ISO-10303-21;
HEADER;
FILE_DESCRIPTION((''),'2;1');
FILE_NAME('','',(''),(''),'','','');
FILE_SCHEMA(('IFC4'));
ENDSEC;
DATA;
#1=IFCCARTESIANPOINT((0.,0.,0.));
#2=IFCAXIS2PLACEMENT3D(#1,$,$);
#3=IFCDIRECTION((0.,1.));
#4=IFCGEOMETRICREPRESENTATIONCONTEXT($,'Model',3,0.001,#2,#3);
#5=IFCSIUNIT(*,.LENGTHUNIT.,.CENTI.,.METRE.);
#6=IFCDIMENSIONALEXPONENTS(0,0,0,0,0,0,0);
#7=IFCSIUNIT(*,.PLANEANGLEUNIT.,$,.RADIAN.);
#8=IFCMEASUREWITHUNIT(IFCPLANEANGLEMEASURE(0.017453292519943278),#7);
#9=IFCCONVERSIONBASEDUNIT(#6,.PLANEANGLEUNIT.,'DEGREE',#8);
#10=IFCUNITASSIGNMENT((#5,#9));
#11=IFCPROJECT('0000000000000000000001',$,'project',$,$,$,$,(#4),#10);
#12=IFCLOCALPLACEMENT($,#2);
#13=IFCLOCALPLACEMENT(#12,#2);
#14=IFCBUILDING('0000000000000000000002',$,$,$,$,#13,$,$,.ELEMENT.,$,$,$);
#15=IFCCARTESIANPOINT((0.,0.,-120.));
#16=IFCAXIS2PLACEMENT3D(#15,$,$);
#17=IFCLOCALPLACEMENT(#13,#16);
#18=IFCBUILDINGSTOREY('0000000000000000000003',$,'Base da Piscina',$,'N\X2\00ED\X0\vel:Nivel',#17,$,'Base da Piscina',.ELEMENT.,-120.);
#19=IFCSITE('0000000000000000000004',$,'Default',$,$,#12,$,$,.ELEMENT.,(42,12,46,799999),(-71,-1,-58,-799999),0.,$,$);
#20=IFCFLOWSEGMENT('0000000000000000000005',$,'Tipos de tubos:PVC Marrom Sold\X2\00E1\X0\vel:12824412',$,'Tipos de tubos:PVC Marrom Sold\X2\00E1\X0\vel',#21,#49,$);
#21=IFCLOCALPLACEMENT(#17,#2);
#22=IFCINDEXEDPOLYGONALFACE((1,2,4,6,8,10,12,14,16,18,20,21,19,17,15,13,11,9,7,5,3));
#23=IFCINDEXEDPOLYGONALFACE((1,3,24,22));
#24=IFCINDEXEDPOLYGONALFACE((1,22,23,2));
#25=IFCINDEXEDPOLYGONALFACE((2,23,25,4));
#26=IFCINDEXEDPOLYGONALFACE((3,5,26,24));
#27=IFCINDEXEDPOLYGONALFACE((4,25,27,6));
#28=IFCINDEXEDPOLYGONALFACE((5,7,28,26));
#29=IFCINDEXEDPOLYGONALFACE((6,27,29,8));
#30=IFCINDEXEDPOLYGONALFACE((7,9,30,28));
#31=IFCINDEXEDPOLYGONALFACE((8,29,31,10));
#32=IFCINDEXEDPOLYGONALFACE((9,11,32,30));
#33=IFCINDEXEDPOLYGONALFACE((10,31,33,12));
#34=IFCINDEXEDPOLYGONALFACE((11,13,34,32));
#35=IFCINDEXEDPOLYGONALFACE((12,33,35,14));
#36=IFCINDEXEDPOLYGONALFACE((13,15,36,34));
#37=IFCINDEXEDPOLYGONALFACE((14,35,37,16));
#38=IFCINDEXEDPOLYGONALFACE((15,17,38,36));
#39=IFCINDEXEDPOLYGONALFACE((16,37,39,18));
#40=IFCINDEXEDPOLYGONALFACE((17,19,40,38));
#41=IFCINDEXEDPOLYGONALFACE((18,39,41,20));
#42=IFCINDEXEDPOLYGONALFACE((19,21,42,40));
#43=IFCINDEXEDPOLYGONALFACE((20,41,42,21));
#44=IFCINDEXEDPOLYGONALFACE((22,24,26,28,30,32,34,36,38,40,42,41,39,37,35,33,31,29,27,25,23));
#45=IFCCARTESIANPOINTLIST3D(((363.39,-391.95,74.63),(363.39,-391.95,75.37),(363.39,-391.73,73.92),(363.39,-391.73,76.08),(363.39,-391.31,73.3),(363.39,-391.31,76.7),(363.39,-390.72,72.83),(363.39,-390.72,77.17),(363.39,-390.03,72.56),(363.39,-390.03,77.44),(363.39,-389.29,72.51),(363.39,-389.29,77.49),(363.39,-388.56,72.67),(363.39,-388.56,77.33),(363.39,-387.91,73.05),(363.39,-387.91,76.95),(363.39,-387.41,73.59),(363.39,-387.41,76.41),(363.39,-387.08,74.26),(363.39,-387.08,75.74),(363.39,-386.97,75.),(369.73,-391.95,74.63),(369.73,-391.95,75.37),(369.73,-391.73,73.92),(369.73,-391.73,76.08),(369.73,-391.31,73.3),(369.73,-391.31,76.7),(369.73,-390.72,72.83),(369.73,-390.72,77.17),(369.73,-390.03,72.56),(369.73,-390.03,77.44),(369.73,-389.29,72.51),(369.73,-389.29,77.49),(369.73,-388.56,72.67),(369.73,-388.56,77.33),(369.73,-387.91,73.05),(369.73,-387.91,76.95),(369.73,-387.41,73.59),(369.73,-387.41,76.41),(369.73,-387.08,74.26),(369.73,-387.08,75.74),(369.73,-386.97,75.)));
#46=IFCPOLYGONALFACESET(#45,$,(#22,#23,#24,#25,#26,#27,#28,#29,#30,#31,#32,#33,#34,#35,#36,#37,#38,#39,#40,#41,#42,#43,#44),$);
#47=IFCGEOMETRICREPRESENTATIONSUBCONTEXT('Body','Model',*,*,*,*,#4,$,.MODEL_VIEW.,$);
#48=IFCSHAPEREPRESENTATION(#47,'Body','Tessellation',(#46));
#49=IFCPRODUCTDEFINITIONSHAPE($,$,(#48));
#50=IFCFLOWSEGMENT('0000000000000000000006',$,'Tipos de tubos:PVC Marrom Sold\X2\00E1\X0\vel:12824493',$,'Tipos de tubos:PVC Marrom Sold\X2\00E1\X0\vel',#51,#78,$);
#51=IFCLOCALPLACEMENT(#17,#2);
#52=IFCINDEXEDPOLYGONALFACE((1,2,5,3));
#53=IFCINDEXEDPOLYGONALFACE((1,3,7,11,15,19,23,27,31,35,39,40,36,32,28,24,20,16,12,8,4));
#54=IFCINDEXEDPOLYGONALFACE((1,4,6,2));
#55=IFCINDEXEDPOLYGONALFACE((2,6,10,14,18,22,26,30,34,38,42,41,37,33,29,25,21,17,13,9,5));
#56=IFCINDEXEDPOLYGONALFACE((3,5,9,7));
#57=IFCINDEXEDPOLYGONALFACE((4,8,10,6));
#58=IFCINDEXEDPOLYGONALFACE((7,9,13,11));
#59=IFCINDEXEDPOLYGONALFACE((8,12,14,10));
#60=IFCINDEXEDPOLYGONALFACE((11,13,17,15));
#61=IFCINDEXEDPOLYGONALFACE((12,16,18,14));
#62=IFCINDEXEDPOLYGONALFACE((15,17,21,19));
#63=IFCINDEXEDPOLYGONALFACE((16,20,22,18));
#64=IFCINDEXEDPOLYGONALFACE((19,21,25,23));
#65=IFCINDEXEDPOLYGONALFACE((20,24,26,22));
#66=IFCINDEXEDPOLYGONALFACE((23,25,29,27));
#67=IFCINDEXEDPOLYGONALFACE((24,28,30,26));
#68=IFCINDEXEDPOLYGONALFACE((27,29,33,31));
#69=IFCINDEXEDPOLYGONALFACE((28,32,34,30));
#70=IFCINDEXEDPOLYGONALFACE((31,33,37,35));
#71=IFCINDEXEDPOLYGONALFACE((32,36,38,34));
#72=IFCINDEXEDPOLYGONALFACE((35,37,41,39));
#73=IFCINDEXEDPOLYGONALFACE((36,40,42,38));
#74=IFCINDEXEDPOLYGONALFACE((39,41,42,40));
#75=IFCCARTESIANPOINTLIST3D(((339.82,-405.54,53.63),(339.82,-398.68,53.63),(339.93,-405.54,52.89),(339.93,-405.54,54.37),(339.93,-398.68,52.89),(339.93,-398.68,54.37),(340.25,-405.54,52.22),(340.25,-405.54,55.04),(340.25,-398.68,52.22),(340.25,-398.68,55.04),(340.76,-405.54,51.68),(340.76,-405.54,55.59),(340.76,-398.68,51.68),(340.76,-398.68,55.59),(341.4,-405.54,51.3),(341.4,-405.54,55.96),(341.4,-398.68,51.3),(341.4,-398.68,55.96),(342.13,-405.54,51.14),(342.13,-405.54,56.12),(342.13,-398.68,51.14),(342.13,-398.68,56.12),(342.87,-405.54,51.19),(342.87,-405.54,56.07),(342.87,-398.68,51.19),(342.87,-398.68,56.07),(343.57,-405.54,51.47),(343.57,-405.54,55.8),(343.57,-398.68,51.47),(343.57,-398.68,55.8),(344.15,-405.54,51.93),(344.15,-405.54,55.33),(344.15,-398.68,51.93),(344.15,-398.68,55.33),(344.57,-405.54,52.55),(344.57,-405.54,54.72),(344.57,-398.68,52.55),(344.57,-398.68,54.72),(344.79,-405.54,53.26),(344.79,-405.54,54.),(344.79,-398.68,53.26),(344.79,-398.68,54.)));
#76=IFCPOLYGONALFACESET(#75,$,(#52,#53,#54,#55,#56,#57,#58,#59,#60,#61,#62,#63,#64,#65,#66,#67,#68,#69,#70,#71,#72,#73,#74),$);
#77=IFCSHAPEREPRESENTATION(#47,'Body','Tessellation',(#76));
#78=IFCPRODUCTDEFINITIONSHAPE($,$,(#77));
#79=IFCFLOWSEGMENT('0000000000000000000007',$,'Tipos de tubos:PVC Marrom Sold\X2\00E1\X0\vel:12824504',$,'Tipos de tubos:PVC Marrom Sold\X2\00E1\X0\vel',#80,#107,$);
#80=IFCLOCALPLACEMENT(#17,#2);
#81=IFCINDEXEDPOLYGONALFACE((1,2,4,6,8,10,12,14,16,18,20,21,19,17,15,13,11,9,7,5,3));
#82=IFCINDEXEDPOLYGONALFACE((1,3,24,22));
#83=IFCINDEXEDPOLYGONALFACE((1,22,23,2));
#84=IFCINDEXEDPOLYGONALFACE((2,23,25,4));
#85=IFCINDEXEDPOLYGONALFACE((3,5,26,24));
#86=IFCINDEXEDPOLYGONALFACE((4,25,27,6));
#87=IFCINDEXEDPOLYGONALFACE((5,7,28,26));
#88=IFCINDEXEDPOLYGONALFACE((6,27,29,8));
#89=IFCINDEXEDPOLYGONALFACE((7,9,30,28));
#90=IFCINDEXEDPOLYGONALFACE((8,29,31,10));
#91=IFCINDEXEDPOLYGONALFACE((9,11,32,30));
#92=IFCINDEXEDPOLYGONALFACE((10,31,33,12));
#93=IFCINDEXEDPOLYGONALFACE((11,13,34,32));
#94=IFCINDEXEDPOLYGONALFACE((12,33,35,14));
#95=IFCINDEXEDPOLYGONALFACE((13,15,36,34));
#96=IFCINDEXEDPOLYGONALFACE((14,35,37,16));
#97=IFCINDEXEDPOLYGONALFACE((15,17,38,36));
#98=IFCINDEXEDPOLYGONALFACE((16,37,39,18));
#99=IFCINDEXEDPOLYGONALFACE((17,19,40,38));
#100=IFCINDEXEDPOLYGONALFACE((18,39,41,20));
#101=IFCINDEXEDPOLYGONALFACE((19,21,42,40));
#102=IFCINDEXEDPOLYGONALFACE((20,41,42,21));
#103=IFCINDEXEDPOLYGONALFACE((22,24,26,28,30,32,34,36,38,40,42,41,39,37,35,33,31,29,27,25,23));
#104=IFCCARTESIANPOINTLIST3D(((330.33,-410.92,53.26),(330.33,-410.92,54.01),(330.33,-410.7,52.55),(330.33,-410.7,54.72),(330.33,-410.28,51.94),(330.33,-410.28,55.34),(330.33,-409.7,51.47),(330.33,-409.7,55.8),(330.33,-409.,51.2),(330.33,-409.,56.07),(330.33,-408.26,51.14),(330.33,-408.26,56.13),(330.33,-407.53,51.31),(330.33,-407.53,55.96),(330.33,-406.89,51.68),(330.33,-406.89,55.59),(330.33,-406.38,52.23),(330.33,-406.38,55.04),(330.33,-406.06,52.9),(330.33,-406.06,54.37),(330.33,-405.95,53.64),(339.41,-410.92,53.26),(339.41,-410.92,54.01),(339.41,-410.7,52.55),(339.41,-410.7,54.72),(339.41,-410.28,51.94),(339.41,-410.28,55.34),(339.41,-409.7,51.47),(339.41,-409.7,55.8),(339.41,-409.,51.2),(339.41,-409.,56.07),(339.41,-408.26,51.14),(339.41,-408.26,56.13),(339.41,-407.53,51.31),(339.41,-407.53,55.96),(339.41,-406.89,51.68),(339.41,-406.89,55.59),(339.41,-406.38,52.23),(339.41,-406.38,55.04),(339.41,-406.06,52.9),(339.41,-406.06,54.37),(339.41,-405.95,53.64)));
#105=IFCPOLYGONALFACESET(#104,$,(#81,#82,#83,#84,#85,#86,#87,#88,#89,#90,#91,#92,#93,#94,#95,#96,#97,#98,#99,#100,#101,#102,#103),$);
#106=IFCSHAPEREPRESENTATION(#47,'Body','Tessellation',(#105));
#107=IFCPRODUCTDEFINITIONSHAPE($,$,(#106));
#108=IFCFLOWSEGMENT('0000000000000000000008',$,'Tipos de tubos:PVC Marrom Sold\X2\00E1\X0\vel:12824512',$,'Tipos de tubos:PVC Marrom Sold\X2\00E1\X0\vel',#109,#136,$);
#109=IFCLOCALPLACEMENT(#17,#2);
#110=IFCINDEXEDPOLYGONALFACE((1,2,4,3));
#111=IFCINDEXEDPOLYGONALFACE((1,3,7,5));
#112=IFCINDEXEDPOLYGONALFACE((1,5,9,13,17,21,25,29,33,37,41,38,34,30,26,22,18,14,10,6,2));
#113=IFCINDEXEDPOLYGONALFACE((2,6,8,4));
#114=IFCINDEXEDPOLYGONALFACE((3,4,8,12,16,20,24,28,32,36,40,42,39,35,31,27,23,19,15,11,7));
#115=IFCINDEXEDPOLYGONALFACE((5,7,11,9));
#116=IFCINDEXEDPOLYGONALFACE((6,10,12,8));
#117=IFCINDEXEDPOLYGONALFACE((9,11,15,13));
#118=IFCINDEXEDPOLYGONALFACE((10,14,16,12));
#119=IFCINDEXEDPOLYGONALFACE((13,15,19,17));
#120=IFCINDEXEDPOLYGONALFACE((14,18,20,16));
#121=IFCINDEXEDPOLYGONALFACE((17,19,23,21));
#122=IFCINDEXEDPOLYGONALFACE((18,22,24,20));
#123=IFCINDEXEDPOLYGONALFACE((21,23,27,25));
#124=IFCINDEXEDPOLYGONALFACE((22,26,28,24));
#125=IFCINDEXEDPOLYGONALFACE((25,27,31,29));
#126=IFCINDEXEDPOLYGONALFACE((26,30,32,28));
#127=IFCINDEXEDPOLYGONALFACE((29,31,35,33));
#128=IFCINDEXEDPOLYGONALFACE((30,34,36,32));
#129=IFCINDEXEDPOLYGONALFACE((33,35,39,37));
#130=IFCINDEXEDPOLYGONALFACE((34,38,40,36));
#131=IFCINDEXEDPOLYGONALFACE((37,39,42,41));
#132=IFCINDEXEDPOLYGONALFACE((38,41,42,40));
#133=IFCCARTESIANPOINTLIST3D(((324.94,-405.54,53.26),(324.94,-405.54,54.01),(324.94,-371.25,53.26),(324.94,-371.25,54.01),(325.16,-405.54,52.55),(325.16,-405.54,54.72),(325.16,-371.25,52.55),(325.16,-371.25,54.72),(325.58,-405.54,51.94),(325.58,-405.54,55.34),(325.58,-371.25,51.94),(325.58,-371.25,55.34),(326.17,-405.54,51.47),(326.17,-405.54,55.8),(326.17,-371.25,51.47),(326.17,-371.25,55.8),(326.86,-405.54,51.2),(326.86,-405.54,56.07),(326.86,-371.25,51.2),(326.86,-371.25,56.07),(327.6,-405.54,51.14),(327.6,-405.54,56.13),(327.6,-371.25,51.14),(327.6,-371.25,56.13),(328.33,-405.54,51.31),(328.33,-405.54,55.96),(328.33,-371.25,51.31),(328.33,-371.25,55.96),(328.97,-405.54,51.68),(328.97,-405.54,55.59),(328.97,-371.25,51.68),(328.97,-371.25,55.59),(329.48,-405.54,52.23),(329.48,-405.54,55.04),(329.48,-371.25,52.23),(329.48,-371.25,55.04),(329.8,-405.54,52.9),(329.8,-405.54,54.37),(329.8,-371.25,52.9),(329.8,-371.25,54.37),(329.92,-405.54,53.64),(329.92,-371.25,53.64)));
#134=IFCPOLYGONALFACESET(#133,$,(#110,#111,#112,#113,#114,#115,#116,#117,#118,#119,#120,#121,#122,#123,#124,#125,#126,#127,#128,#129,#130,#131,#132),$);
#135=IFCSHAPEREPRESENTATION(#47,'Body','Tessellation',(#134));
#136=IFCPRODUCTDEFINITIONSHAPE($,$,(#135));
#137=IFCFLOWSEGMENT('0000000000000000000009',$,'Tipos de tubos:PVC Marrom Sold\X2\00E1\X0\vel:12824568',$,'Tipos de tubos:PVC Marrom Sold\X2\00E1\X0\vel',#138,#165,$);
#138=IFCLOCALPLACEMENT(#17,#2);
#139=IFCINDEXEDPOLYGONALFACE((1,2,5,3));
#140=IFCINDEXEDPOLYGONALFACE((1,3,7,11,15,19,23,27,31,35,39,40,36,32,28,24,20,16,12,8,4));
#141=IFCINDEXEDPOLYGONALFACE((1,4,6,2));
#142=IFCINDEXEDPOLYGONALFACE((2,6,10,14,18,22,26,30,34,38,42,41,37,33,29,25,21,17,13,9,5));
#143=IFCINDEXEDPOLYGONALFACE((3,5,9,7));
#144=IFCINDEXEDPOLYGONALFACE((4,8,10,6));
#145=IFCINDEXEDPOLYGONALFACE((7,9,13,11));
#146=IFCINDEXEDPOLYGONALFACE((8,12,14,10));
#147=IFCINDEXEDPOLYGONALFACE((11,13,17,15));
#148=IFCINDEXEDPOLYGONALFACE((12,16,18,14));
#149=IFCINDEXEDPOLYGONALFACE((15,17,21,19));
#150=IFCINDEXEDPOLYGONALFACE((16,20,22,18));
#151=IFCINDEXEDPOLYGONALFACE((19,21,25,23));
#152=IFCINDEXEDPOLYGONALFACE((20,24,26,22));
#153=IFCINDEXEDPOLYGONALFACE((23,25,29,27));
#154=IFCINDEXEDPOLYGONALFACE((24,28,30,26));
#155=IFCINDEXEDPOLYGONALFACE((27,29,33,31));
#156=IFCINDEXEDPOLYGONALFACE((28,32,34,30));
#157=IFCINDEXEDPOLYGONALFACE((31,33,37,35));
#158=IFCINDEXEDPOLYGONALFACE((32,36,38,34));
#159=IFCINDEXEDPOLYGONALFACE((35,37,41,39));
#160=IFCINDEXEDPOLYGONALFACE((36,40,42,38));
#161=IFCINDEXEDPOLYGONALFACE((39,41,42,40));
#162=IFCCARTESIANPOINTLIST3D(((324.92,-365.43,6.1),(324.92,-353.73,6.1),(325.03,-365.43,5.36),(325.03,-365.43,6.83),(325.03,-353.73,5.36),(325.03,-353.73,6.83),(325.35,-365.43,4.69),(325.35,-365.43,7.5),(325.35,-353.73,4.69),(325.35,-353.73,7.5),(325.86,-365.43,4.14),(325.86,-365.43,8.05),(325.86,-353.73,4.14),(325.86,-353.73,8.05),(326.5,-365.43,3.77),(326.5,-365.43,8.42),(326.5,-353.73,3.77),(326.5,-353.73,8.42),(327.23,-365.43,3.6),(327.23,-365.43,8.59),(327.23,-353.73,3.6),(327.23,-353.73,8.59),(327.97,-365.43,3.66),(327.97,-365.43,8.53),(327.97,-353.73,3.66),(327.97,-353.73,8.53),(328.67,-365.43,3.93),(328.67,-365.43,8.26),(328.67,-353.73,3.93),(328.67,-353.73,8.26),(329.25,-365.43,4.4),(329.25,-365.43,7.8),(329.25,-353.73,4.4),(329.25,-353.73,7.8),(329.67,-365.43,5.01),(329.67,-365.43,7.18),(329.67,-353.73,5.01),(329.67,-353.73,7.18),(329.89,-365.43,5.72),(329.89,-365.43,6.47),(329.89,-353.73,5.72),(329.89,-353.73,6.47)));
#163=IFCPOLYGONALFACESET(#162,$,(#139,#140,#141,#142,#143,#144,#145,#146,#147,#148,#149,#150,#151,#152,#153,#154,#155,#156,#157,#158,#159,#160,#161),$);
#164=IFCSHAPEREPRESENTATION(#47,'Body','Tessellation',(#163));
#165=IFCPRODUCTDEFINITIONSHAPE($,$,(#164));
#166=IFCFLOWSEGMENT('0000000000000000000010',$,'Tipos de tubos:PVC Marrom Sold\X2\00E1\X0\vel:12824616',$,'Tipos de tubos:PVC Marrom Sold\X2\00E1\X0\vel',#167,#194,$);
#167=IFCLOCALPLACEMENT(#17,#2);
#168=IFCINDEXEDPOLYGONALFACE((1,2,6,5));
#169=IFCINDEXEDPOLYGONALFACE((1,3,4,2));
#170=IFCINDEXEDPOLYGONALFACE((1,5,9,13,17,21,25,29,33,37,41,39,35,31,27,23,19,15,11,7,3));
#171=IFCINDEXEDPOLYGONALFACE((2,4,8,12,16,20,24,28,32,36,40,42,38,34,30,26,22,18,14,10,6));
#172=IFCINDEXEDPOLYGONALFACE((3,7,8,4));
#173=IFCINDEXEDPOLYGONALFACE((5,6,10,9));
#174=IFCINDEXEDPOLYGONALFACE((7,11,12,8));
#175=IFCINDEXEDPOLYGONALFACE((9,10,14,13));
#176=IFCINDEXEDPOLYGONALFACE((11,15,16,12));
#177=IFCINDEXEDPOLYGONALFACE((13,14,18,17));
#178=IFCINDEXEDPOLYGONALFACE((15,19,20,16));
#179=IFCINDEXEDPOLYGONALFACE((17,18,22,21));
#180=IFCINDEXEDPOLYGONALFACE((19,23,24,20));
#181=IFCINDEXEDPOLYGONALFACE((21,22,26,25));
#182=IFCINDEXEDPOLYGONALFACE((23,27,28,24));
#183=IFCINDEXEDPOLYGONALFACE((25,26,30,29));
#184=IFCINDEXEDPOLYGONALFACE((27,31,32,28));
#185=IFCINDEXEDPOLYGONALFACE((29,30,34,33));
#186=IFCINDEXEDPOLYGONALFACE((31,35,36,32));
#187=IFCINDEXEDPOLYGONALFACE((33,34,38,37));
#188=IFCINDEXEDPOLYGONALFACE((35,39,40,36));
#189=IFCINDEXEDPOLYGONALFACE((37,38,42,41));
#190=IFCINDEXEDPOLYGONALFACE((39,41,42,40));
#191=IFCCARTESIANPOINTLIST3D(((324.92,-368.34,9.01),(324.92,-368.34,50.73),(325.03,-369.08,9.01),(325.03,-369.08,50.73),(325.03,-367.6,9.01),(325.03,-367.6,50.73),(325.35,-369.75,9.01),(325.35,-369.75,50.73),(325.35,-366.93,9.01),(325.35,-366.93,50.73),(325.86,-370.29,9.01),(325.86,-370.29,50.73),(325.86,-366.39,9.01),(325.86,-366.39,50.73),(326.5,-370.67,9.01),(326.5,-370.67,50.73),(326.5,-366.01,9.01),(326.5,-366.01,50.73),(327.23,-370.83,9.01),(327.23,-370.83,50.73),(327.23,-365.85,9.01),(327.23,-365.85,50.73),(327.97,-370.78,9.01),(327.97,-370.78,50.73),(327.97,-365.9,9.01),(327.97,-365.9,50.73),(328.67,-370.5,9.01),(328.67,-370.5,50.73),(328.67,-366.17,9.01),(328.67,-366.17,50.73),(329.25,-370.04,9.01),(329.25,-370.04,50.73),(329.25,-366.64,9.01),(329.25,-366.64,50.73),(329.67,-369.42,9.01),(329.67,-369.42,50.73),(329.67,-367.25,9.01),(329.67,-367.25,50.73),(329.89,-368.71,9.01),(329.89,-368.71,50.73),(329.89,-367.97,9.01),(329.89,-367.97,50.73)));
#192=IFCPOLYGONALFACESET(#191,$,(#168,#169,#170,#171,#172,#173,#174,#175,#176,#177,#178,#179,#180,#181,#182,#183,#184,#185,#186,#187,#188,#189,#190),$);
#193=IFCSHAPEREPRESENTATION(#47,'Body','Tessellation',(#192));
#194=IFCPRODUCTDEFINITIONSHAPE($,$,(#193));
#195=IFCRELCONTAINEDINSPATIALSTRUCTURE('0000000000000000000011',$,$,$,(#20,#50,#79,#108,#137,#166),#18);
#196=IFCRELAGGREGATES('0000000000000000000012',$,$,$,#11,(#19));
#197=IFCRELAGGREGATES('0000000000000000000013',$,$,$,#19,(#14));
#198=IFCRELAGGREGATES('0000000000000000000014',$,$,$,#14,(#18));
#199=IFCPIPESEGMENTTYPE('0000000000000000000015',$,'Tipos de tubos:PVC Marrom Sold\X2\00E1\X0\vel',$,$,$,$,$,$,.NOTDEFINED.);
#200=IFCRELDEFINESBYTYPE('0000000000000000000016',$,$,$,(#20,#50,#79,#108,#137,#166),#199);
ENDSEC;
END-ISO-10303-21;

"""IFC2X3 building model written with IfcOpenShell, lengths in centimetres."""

from ifc_helpers import new_model, entity, si_unit, converted_unit, direction, frame, frame_2d, origin, origin_2d_with_axis, place, context, subcontext, project, spatial, circle, extrude, type_object, element, save


model = new_model("IFC2X3")

# Units and contexts
model_context = context("Model", 3, precision=0.001, world=origin(), true_north=direction((0.0, 1.0)))
body_context = subcontext(model_context, "Body", "Model", "MODEL_VIEW")
ifc_project = project(units=[si_unit("LENGTHUNIT", "METRE", prefix="CENTI"), converted_unit("PLANEANGLEUNIT", "DEGREE", entity("IfcPlaneAngleMeasure", 0.017453292519943278), si_unit("PLANEANGLEUNIT", "RADIAN"), dimensions=[0, 0, 0, 0, 0, 0, 0])], contexts=[model_context])

# Site, building, storey
site_placement = place(None, origin())
site = spatial("IfcSite", under=ifc_project, at=site_placement, Name="Default", CompositionType="ELEMENT", RefLatitude=(42, 12, 46, 799999), RefLongitude=(-71, -1, -58, -799999), RefElevation=0.0)
building_placement = place(site_placement, origin())
building = spatial("IfcBuilding", under=site, at=building_placement, CompositionType="ELEMENT")
storey_placement = place(building_placement, frame((0.0, 0.0, -120.0)))
storey = spatial("IfcBuildingStorey", under=building, at=storey_placement, Name="Base da Piscina", ObjectType="Nível:Nivel", LongName="Base da Piscina", CompositionType="ELEMENT", Elevation=-120.0)

# Flow segments
pipe_segment_type = type_object("IfcPipeSegmentType", Name="Tipos de tubos:PVC Marrom Soldável", PredefinedType="NOTDEFINED")
flow_segment_1_placement = place(storey_placement, origin())
element("IfcFlowSegment", 1, at=flow_segment_1_placement, inside=storey, type_object=pipe_segment_type, Name="Tipos de tubos:PVC Marrom Soldável:12824412", ObjectType="Tipos de tubos:PVC Marrom Soldável", context=body_context, shape_type="SweptSolid", body=[
    extrude(circle(Radius=2.5, at=frame_2d((0.0, 0.0), x_axis=(1.0, 0.0))), frame((363.39, -389.47, 75.0), z_axis=(1.0, 0.000024, 0.0), x_axis=(-0.000024, 1.0, 0.0)), (0.0, 0.0, 1.0), 6.34),
])
flow_segment_2_placement = place(storey_placement, origin())
element("IfcFlowSegment", 2, at=flow_segment_2_placement, inside=storey, type_object=pipe_segment_type, Name="Tipos de tubos:PVC Marrom Soldável:12824493", ObjectType="Tipos de tubos:PVC Marrom Soldável", context=body_context, shape_type="SweptSolid", body=[
    extrude(circle(Radius=2.5, at=origin_2d_with_axis()), frame((342.32, -405.54, 53.63), z_axis=(0.0, 1.0, 0.0), x_axis=(-1.0, 0.0, 0.0)), (0.0, 0.0, 1.0), 6.86),
])
flow_segment_3_placement = place(storey_placement, origin())
element("IfcFlowSegment", 3, at=flow_segment_3_placement, inside=storey, type_object=pipe_segment_type, Name="Tipos de tubos:PVC Marrom Soldável:12824504", ObjectType="Tipos de tubos:PVC Marrom Soldável", context=body_context, shape_type="SweptSolid", body=[
    extrude(circle(Radius=2.5, at=frame_2d((0.0, 0.0), x_axis=(1.0, 0.0))), frame((330.33, -408.45, 53.64), z_axis=(1.0, 0.0, 0.0), x_axis=(0.0, 1.0, 0.0)), (0.0, 0.0, 1.0), 9.08),
])
flow_segment_4_placement = place(storey_placement, origin())
element("IfcFlowSegment", 4, at=flow_segment_4_placement, inside=storey, type_object=pipe_segment_type, Name="Tipos de tubos:PVC Marrom Soldável:12824512", ObjectType="Tipos de tubos:PVC Marrom Soldável", context=body_context, shape_type="SweptSolid", body=[
    extrude(circle(Radius=2.5, at=origin_2d_with_axis()), frame((327.42, -405.54, 53.64), z_axis=(0.0, 1.0, 0.0), x_axis=(1.0, 0.0, 0.0)), (0.0, 0.0, 1.0), 34.29),
])
flow_segment_5_placement = place(storey_placement, origin())
element("IfcFlowSegment", 5, at=flow_segment_5_placement, inside=storey, type_object=pipe_segment_type, Name="Tipos de tubos:PVC Marrom Soldável:12824568", ObjectType="Tipos de tubos:PVC Marrom Soldável", context=body_context, shape_type="SweptSolid", body=[
    extrude(circle(Radius=2.5, at=origin_2d_with_axis()), frame((327.42, -365.43, 6.1), z_axis=(0.0, 1.0, 0.0), x_axis=(-1.0, 0.0, 0.0)), (0.0, 0.0, 1.0), 11.7),
])
flow_segment_6_placement = place(storey_placement, origin())
element("IfcFlowSegment", 6, at=flow_segment_6_placement, inside=storey, type_object=pipe_segment_type, Name="Tipos de tubos:PVC Marrom Soldável:12824616", ObjectType="Tipos de tubos:PVC Marrom Soldável", context=body_context, shape_type="SweptSolid", body=[
    extrude(circle(Radius=2.5, at=origin_2d_with_axis()), frame((327.42, -368.34, 9.01), z_axis=(0.0, 0.0, 1.0), x_axis=(-1.0, 0.0, 0.0)), (0.0, 0.0, 1.0), 41.72),
])

save(model, "model.ifc")
